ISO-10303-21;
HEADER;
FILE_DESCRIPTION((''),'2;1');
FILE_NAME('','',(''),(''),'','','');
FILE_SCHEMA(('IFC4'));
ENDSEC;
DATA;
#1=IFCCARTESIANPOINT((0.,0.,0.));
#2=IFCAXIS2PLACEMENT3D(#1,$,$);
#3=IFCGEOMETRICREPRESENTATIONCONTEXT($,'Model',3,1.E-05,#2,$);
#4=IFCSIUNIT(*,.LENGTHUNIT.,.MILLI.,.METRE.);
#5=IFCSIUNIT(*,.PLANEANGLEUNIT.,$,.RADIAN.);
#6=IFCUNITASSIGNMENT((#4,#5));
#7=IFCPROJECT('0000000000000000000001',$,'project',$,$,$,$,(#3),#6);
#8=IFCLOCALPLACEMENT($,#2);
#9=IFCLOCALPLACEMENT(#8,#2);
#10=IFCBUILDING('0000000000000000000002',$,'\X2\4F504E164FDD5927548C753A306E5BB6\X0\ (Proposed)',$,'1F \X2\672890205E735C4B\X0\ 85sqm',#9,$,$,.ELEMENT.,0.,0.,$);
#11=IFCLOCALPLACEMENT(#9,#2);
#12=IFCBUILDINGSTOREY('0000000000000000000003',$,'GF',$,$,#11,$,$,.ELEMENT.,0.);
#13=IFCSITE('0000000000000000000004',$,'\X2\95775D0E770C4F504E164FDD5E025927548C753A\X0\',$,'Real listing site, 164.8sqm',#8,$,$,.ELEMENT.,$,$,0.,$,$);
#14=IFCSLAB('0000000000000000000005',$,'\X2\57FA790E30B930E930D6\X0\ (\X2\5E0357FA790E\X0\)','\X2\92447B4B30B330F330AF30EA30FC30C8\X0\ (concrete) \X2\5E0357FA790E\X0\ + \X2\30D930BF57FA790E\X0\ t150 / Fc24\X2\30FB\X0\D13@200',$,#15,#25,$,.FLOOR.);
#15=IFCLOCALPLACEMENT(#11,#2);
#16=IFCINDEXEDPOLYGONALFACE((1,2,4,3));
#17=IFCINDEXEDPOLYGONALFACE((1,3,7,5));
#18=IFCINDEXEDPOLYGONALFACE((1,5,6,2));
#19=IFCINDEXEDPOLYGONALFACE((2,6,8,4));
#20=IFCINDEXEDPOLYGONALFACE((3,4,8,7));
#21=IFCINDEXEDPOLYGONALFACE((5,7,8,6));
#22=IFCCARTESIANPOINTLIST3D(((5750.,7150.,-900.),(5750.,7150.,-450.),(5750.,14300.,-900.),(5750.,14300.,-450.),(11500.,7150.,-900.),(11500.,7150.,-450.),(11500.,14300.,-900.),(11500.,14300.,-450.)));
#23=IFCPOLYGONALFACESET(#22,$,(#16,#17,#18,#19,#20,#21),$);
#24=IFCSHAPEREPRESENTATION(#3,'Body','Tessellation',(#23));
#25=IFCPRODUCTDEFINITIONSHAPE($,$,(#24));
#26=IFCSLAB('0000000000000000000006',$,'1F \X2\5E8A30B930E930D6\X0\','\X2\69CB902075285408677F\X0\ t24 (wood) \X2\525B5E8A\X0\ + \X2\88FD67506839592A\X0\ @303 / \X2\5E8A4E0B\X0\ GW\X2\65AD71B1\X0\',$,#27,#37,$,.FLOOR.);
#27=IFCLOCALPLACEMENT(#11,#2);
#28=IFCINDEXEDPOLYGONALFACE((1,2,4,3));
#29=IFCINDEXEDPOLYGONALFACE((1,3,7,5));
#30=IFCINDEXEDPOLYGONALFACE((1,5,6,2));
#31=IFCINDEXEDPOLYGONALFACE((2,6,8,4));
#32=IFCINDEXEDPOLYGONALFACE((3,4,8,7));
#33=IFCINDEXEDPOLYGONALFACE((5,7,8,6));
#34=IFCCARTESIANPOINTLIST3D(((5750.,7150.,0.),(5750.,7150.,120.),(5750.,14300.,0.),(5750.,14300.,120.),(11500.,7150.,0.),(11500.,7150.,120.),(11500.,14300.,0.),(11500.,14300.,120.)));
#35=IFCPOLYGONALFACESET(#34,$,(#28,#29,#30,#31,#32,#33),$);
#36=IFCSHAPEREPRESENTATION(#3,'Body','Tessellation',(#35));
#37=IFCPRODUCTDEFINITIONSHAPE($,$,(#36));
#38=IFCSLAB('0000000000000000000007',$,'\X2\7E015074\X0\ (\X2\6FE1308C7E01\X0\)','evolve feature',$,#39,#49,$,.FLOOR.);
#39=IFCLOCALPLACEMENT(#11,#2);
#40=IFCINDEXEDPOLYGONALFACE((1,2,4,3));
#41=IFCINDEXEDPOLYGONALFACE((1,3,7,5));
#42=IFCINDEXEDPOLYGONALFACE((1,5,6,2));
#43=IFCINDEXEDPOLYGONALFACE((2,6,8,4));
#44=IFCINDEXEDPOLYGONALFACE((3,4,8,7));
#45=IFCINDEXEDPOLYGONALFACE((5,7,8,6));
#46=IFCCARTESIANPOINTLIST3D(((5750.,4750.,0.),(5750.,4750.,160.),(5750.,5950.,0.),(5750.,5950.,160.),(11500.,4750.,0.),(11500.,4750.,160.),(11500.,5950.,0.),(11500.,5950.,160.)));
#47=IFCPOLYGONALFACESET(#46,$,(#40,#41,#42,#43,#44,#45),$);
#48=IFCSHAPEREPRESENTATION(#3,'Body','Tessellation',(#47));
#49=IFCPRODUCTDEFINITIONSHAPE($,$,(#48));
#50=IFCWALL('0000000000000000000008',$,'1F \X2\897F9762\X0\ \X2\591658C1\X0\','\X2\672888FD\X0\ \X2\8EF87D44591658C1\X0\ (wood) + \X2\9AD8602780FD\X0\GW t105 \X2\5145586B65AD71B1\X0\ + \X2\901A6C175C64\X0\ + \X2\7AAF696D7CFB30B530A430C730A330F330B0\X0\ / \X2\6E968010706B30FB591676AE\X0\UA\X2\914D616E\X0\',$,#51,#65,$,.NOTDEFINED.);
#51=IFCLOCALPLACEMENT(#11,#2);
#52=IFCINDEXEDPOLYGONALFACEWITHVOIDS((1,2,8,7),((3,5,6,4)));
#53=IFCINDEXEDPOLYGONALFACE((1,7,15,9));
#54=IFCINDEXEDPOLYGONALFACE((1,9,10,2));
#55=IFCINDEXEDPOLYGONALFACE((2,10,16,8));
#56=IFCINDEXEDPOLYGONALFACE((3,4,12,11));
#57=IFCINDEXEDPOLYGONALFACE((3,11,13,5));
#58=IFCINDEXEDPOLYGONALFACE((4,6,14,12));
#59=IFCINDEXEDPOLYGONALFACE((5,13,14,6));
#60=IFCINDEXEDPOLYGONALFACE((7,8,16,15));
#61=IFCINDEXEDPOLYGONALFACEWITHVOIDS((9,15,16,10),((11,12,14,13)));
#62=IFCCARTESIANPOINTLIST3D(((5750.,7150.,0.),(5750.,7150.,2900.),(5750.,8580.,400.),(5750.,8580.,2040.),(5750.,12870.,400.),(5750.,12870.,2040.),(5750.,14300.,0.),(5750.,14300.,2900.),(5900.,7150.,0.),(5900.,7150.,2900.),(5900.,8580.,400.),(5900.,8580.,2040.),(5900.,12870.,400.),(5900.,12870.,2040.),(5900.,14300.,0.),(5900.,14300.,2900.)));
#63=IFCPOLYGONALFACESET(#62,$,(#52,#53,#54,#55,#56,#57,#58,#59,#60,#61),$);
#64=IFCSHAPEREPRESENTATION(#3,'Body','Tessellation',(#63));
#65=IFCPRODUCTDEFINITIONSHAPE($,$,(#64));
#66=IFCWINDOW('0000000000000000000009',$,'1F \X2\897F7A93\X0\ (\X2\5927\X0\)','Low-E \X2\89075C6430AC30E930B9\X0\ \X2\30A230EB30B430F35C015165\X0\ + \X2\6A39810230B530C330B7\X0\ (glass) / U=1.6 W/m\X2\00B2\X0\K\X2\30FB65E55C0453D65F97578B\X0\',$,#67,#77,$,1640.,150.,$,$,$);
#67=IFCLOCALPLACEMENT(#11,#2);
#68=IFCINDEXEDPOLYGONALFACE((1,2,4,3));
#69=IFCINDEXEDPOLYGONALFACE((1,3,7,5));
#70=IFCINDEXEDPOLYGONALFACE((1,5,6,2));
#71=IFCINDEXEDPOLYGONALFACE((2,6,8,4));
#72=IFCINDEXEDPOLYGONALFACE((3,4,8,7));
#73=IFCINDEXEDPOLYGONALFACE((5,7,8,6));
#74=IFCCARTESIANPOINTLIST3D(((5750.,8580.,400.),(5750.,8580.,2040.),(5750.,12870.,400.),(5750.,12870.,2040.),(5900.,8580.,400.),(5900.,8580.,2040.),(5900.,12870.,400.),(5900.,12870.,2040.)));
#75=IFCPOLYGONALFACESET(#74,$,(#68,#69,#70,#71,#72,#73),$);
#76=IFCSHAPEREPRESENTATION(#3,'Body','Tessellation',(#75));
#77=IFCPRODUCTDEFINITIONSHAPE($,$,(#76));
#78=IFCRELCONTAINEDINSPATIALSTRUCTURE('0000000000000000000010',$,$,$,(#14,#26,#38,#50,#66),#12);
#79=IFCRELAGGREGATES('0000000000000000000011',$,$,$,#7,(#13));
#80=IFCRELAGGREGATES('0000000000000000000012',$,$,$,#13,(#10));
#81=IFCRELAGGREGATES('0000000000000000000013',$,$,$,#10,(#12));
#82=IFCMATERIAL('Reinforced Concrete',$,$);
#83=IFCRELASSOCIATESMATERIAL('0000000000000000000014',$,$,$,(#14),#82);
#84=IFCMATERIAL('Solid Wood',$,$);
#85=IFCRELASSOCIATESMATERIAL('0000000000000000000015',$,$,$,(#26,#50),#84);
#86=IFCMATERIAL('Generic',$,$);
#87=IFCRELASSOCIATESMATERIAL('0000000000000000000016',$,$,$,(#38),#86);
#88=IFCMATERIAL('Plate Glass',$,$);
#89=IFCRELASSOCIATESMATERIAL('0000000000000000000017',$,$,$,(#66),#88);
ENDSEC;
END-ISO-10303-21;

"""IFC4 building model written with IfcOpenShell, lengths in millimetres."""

from ifc_helpers import new_model, si_unit, frame, frame_2d, origin, place, context, project, spatial, rectangle, extrude, material, element, fill, save


model = new_model("IFC4")

# Units and contexts
model_context = context("Model", 3, precision=1e-05, world=origin())
ifc_project = project(units=[si_unit("LENGTHUNIT", "METRE", prefix="MILLI"), si_unit("PLANEANGLEUNIT", "RADIAN")], contexts=[model_context])

# Site, building, storey
site_placement = place(None, origin())
site = spatial("IfcSite", under=ifc_project, at=site_placement, Name="長崎県佐世保市大和町", ObjectType="Real listing site, 164.8sqm", CompositionType="ELEMENT", RefElevation=0.0)
building_placement = place(site_placement, origin())
building = spatial("IfcBuilding", under=site, at=building_placement, Name="佐世保大和町の家 (Proposed)", ObjectType="1F 木造平屋 85sqm", CompositionType="ELEMENT", ElevationOfRefHeight=0.0, ElevationOfTerrain=0.0)
storey_placement = place(building_placement, origin())
storey = spatial("IfcBuildingStorey", under=building, at=storey_placement, Name="GF", CompositionType="ELEMENT", Elevation=0.0)

# Slabs
ifc_material_1 = material(Name="Reinforced Concrete")
slab_1_placement = place(storey_placement, frame((2875.0, 3575.0, -450.0)))
element("IfcSlab", 1, at=slab_1_placement, inside=storey, material=ifc_material_1, Name="基礎スラブ (布基礎)", Description="鉄筋コンクリート (concrete) 布基礎 + ベタ基礎 t150 / Fc24・D13@200", PredefinedType="FLOOR", context=model_context, shape_type="SweptSolid", body=[
    extrude(rectangle(XDim=5750.0, YDim=7150.0, at=frame_2d((2875.0, 3575.0))), frame((2875.0, 3575.0, -450.0)), (0.0, 0.0, 1.0), 450.0),
])
ifc_material_2 = material(Name="Solid Wood")
slab_2_placement = place(storey_placement, frame((2875.0, 3575.0, 0.0)))
element("IfcSlab", 2, at=slab_2_placement, inside=storey, material=ifc_material_2, Name="1F 床スラブ", Description="構造用合板 t24 (wood) 剛床 + 製材根太 @303 / 床下 GW断熱", PredefinedType="FLOOR", context=model_context, shape_type="SweptSolid", body=[
    extrude(rectangle(XDim=5750.0, YDim=7150.0, at=frame_2d((2875.0, 3575.0))), frame((2875.0, 3575.0, 0.0)), (0.0, 0.0, 1.0), 120.0),
])
ifc_material_3 = material(Name="Generic")
slab_3_placement = place(storey_placement, frame((2875.0, 2375.0, 0.0)))
element("IfcSlab", 3, at=slab_3_placement, inside=storey, material=ifc_material_3, Name="縁側 (濡れ縁)", Description="evolve feature", PredefinedType="FLOOR", context=model_context, shape_type="SweptSolid", body=[
    extrude(rectangle(XDim=5750.0, YDim=1200.0, at=frame_2d((2875.0, 600.0))), frame((2875.0, 2375.0, 0.0)), (0.0, 0.0, 1.0), 160.0),
])

# Shared definitions
ifc_material_4 = material(Name="Plate Glass")

# Wall, opening, window
wall_1_placement = place(storey_placement, frame((2875.0, 3575.0, 0.0)))
wall_1 = element("IfcWall", 4, at=wall_1_placement, inside=storey, material=ifc_material_2, Name="1F 西面 外壁", Description="木製 軸組外壁 (wood) + 高性能GW t105 充填断熱 + 通気層 + 窯業系サイディング / 準耐火・外皮UA配慮", PredefinedType="NOTDEFINED", context=model_context, shape_type="SweptSolid", body=[
    extrude(rectangle(XDim=150.0, YDim=7150.0, at=frame_2d((75.0, 3575.0))), frame((2875.0, 3575.0, 0.0)), (0.0, 0.0, 1.0), 2900.0),
])
opening_1_placement = place(storey_placement, frame((2875.0, 4290.0, 200.0)))
opening_1 = element("IfcOpeningElement", 5, at=opening_1_placement, cuts=wall_1, PredefinedType="NOTDEFINED", context=model_context, shape_type="SweptSolid", body=[
    extrude(rectangle(XDim=150.0, YDim=4290.0, at=frame_2d((75.0, 2145.0))), frame((2875.0, 4290.0, 200.0)), (0.0, 0.0, 1.0), 1640.0),
])
window_1_placement = place(storey_placement, frame((2875.0, 4290.0, 200.0)))
window_1 = element("IfcWindow", 6, at=window_1_placement, inside=storey, material=ifc_material_4, Name="1F 西窓 (大)", Description="Low-E 複層ガラス アルゴン封入 + 樹脂サッシ (glass) / U=1.6 W/m²K・日射取得型", OverallHeight=1640.0, OverallWidth=150.0, context=model_context, shape_type="SweptSolid", body=[
    extrude(rectangle(XDim=150.0, YDim=4290.0, at=frame_2d((75.0, 2145.0))), frame((2875.0, 4290.0, 200.0)), (0.0, 0.0, 1.0), 1640.0),
])
fill(opening_1, window_1)

save(model, "model.ifc")
